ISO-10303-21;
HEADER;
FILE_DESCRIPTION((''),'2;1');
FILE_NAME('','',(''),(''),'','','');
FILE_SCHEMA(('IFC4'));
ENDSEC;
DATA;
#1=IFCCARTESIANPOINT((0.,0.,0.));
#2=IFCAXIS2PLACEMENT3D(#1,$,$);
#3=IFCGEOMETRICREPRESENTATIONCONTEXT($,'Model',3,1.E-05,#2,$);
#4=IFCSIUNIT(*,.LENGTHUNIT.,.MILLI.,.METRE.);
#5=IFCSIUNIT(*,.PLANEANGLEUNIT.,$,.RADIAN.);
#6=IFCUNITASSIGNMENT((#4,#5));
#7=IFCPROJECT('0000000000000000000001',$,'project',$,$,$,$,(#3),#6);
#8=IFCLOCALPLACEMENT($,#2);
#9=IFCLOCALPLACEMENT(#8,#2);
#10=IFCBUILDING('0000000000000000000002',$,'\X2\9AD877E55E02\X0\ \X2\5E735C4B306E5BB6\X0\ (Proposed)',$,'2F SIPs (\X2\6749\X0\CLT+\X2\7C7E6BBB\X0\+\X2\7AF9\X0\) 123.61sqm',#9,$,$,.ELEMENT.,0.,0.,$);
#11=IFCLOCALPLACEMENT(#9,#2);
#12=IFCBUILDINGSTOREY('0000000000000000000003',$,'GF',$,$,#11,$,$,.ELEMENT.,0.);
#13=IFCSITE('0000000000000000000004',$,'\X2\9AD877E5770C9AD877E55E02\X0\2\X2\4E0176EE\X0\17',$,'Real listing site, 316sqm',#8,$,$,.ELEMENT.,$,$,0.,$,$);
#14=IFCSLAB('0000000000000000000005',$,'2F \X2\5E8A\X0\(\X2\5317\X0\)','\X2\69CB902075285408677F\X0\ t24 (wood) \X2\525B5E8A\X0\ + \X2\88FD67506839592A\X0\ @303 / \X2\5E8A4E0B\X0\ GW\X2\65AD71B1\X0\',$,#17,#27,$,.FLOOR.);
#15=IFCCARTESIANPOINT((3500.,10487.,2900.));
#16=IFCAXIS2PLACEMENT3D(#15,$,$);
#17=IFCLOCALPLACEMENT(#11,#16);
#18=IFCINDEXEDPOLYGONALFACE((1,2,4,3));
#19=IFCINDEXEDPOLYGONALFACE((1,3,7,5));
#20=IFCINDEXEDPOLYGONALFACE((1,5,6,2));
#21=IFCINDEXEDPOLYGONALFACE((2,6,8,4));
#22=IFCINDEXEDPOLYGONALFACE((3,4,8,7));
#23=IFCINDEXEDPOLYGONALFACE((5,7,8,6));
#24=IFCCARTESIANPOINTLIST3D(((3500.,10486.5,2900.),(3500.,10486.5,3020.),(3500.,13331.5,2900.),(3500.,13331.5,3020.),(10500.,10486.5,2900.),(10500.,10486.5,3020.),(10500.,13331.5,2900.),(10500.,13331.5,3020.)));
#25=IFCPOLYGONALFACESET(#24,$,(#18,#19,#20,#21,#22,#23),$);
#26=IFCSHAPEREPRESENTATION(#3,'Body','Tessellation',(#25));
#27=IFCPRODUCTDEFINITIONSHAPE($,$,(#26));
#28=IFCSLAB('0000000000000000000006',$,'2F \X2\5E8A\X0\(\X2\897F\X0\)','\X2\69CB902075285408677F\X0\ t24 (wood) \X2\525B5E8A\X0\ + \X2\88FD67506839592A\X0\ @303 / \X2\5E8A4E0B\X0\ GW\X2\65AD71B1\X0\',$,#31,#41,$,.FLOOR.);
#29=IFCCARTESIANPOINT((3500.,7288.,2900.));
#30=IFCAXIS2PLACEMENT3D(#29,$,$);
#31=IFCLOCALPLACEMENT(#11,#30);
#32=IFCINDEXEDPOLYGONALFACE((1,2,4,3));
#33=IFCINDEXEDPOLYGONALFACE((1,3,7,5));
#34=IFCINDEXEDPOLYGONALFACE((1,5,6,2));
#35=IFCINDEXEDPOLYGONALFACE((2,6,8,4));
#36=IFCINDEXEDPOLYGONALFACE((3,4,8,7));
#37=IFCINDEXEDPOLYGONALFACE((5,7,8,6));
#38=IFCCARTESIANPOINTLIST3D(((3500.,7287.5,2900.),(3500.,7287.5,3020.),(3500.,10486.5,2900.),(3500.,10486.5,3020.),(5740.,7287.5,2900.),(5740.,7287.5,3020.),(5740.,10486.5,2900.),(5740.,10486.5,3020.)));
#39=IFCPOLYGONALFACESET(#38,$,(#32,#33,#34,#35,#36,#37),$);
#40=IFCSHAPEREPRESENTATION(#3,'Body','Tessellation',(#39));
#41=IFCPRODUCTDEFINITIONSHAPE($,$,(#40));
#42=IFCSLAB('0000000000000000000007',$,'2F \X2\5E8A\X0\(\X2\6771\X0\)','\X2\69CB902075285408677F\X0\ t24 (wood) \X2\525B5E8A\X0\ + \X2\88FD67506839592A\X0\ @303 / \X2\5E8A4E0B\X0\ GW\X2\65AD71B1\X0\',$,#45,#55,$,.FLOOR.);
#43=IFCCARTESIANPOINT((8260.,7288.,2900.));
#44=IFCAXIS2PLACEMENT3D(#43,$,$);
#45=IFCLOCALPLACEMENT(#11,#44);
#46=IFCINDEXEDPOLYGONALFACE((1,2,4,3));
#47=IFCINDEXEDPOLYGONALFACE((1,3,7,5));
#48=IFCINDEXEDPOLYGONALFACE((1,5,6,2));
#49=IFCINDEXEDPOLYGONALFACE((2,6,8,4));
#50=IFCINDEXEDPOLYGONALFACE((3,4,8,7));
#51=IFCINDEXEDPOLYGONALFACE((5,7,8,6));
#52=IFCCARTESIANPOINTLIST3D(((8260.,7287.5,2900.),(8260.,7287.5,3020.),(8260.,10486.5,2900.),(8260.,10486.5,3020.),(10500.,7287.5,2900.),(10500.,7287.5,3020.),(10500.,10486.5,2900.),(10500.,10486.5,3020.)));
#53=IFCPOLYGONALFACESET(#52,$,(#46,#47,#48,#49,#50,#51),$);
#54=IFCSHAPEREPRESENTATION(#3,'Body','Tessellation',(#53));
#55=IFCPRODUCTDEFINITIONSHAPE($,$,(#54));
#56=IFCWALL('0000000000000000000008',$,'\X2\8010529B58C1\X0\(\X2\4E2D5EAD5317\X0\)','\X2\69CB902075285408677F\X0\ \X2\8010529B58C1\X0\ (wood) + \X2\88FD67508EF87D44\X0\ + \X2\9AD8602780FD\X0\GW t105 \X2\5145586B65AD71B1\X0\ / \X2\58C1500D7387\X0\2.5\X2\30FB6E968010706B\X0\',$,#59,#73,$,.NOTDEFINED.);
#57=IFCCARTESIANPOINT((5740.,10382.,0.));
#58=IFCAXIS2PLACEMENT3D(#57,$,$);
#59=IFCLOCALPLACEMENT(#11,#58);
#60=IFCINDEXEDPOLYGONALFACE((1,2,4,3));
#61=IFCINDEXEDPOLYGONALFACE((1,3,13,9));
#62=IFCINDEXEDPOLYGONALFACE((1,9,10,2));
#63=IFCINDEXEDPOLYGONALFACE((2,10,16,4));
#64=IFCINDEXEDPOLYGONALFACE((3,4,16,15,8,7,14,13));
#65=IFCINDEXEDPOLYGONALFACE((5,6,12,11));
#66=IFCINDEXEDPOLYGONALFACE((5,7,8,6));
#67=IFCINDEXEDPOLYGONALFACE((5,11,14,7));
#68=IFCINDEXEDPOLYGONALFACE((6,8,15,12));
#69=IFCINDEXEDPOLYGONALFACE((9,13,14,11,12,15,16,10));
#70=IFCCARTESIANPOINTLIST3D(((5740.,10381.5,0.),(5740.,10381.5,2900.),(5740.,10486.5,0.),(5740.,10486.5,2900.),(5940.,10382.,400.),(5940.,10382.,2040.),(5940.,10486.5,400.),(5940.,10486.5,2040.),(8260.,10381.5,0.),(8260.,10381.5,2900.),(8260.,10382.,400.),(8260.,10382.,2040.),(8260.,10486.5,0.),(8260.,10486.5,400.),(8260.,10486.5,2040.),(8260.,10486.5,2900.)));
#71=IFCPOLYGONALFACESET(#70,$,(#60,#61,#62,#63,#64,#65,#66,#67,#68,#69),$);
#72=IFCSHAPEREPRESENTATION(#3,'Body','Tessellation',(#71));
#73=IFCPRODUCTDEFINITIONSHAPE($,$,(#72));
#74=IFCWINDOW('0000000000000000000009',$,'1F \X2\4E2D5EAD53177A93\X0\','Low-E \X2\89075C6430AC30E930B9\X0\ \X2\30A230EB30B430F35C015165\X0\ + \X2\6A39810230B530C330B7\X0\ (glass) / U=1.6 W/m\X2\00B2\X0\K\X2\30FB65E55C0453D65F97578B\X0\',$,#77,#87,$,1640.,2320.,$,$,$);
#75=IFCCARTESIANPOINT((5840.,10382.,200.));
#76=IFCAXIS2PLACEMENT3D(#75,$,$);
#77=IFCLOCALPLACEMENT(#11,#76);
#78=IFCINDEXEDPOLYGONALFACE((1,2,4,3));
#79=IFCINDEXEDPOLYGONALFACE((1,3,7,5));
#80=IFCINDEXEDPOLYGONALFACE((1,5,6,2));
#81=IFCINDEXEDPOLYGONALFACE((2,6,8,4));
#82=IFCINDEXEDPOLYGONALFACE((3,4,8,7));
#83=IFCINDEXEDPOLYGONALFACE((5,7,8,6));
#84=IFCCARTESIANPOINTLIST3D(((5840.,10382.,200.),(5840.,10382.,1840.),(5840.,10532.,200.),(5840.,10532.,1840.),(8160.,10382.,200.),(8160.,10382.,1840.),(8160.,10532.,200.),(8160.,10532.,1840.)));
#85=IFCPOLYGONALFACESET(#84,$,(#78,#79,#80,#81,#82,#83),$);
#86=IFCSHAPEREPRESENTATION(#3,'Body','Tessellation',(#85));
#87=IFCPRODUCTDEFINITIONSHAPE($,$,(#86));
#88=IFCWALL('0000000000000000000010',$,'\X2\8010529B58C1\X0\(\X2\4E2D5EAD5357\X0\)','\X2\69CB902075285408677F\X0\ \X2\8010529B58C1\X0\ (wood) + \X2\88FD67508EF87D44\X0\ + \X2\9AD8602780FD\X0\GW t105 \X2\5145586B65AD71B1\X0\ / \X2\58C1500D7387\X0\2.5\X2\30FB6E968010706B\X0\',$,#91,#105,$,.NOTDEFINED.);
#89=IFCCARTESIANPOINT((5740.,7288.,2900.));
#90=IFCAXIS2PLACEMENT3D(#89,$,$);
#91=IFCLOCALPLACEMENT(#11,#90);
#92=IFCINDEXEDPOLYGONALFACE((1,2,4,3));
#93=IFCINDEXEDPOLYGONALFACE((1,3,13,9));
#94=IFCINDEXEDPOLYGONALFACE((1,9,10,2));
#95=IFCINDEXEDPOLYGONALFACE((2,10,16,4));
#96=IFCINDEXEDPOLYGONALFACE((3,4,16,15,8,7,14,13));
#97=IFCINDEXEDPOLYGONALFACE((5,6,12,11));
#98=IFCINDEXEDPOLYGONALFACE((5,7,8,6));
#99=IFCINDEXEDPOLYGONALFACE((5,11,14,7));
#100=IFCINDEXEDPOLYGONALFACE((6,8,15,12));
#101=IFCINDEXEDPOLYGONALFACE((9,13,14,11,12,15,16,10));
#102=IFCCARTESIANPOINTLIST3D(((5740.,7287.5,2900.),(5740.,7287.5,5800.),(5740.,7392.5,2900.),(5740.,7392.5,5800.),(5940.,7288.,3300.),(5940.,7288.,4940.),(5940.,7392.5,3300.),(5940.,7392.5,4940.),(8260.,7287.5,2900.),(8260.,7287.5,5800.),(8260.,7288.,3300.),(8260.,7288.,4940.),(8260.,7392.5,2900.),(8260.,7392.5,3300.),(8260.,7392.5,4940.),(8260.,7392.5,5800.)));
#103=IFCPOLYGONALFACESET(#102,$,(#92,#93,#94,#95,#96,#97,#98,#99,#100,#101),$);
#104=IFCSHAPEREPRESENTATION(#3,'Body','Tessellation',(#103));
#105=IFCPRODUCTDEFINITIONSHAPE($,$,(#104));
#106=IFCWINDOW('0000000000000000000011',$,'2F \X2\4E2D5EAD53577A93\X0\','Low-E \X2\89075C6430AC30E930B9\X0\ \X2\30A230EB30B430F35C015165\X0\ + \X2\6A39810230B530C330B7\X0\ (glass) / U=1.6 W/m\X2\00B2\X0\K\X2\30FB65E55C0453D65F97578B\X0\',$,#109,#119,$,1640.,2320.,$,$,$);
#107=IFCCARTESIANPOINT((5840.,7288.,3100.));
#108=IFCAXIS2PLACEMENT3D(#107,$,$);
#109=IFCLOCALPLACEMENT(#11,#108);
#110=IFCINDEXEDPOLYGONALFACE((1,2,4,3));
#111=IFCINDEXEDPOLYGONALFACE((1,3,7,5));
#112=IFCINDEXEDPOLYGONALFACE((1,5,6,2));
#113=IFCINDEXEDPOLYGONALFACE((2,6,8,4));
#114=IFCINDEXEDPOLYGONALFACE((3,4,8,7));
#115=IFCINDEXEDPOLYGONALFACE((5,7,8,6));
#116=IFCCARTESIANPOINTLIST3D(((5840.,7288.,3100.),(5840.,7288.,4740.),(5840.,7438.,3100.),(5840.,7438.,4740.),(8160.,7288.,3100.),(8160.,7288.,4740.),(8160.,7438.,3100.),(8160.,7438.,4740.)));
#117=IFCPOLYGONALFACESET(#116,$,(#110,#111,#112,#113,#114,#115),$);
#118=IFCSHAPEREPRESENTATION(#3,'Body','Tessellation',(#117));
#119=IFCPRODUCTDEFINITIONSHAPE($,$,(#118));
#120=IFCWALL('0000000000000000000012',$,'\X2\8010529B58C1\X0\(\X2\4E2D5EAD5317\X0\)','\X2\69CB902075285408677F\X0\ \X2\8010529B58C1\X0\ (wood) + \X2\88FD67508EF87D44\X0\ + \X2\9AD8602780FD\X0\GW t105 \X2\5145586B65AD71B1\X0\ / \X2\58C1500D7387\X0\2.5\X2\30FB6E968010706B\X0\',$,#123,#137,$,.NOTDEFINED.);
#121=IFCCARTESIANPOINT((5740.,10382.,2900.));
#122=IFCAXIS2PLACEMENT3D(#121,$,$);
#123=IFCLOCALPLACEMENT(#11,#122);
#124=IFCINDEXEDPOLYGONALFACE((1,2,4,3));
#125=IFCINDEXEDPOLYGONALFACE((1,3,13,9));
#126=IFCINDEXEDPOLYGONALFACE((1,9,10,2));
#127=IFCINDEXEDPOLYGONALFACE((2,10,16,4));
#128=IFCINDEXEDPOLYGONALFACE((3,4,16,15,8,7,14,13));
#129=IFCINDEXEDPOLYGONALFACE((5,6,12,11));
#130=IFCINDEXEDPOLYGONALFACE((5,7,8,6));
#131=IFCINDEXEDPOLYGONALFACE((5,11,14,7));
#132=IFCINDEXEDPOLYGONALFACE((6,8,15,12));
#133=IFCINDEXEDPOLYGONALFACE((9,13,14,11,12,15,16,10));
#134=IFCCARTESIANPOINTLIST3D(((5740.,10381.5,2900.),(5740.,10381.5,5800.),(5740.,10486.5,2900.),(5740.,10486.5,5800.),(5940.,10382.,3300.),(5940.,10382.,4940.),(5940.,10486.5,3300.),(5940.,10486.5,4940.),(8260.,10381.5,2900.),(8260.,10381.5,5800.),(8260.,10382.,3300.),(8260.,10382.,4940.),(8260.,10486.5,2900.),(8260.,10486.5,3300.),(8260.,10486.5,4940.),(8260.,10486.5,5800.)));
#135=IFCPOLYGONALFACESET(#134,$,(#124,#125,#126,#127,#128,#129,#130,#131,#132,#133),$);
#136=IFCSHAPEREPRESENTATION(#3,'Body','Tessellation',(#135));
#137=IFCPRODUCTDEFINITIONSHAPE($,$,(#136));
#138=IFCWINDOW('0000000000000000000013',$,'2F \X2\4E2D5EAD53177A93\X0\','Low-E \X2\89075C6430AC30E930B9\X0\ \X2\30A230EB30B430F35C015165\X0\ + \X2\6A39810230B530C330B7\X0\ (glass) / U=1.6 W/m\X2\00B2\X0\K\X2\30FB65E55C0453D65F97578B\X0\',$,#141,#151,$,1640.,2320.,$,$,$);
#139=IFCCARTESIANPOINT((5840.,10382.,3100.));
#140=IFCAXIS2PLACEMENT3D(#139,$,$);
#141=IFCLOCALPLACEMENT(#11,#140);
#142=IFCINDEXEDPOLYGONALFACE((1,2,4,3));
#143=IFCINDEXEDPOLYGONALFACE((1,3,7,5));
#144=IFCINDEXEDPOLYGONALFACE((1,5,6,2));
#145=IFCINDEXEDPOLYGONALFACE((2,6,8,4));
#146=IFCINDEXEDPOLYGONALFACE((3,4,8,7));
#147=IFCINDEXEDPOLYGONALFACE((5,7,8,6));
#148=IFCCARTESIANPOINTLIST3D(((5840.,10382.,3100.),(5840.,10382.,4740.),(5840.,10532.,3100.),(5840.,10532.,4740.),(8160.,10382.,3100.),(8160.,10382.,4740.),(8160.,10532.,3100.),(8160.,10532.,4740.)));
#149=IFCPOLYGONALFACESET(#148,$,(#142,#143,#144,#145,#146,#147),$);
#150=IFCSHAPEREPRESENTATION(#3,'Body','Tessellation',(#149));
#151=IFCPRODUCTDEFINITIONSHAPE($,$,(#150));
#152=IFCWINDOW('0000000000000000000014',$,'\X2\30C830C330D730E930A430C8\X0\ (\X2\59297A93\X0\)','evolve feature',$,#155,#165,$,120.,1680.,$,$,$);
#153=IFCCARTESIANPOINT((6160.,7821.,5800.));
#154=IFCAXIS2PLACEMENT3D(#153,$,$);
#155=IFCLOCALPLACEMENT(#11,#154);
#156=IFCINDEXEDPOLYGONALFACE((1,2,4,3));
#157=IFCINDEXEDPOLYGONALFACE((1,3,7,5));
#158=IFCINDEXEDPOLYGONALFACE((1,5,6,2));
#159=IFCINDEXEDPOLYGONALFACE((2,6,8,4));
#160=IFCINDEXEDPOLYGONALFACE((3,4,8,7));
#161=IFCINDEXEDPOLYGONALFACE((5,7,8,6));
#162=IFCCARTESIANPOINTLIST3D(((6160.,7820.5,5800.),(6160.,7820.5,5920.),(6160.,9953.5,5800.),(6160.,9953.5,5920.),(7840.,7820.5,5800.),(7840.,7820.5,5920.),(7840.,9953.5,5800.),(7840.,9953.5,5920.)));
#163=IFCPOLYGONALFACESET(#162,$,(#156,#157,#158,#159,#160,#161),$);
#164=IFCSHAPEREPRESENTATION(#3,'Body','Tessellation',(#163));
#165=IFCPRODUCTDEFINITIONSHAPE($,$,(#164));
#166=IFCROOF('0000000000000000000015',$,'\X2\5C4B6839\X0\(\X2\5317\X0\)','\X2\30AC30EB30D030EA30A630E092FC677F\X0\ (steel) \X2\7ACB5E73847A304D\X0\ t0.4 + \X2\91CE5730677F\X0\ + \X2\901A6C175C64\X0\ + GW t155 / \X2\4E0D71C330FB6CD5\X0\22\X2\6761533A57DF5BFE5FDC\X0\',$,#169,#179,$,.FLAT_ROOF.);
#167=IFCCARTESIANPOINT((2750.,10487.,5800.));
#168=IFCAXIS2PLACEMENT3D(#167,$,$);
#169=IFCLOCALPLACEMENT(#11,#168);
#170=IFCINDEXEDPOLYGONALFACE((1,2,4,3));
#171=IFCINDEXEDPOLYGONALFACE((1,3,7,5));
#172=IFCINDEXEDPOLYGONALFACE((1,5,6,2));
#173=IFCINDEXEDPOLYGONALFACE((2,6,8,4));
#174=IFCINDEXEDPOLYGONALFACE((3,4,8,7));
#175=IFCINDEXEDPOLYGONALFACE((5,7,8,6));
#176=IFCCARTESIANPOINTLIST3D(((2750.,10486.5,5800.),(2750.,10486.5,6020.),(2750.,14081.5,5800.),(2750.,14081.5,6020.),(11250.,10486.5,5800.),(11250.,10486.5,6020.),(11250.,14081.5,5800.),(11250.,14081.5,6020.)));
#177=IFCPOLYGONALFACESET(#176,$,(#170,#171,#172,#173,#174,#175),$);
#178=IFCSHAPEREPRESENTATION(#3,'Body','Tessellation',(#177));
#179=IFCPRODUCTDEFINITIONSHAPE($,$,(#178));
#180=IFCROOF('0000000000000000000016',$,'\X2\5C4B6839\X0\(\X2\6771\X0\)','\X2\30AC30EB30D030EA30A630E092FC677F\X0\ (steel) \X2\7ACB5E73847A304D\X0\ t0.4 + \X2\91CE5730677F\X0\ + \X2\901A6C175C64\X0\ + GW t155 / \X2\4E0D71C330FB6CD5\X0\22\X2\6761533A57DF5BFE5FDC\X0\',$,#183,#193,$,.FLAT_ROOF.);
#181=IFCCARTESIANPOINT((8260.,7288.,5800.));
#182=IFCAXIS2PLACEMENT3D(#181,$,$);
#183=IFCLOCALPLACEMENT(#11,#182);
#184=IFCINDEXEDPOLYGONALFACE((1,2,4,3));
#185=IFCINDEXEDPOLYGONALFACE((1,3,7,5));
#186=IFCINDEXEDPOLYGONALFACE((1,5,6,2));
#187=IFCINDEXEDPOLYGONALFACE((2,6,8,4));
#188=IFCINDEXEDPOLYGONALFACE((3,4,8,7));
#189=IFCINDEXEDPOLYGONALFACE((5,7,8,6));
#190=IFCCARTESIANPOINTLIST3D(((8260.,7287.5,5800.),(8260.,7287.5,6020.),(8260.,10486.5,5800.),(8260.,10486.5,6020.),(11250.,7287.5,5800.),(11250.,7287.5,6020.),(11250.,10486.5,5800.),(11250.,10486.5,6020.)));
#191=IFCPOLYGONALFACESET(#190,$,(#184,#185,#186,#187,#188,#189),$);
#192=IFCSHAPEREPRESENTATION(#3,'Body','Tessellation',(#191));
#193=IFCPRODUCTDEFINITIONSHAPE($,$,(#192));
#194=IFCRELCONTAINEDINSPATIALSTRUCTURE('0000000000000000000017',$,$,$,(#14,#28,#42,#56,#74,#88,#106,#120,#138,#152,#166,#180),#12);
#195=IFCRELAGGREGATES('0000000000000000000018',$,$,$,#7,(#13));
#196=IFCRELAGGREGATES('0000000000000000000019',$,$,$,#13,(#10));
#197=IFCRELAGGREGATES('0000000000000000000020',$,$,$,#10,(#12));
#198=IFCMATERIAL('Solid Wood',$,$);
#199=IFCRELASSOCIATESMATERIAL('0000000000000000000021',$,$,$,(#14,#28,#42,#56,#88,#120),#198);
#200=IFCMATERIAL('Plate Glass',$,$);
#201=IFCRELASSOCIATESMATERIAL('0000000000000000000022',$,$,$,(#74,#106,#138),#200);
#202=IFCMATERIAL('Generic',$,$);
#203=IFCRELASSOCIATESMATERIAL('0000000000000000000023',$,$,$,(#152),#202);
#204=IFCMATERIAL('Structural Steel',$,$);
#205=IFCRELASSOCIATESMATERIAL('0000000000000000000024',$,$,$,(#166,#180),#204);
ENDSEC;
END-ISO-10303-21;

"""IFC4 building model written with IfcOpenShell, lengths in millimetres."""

from ifc_helpers import new_model, si_unit, frame, frame_2d, origin, place, context, project, spatial, rectangle, extrude, material, element, fill, save


model = new_model("IFC4")

# Units and contexts
model_context = context("Model", 3, precision=1e-05, world=origin())
ifc_project = project(units=[si_unit("LENGTHUNIT", "METRE", prefix="MILLI"), si_unit("PLANEANGLEUNIT", "RADIAN")], contexts=[model_context])

# Site, building, storey
site_placement = place(None, origin())
site = spatial("IfcSite", under=ifc_project, at=site_placement, Name="高知県高知市2丁目17", ObjectType="Real listing site, 316sqm", CompositionType="ELEMENT", RefElevation=0.0)
building_placement = place(site_placement, origin())
building = spatial("IfcBuilding", under=site, at=building_placement, Name="高知市 平屋の家 (Proposed)", ObjectType="2F SIPs (杉CLT+籾殻+竹) 123.61sqm", CompositionType="ELEMENT", ElevationOfRefHeight=0.0, ElevationOfTerrain=0.0)
storey_placement = place(building_placement, origin())
storey = spatial("IfcBuildingStorey", under=building, at=storey_placement, Name="GF", CompositionType="ELEMENT", Elevation=0.0)

# Slabs
ifc_material_1 = material(Name="Solid Wood")
slab_1_placement = place(storey_placement, frame((3500.0, 10487.0, 2900.0)))
element("IfcSlab", 1, at=slab_1_placement, inside=storey, material=ifc_material_1, Name="2F 床(北)", Description="構造用合板 t24 (wood) 剛床 + 製材根太 @303 / 床下 GW断熱", PredefinedType="FLOOR", context=model_context, shape_type="SweptSolid", body=[
    extrude(rectangle(XDim=7000.0, YDim=2845.0, at=frame_2d((3500.0, 1422.0))), frame((3500.0, 10487.0, 2900.0)), (0.0, 0.0, 1.0), 120.0),
])
slab_2_placement = place(storey_placement, frame((3500.0, 7288.0, 2900.0)))
element("IfcSlab", 2, at=slab_2_placement, inside=storey, material=ifc_material_1, Name="2F 床(西)", Description="構造用合板 t24 (wood) 剛床 + 製材根太 @303 / 床下 GW断熱", PredefinedType="FLOOR", context=model_context, shape_type="SweptSolid", body=[
    extrude(rectangle(XDim=2240.0, YDim=3199.0, at=frame_2d((1120.0, 1599.0))), frame((3500.0, 7288.0, 2900.0)), (0.0, 0.0, 1.0), 120.0),
])
slab_3_placement = place(storey_placement, frame((8260.0, 7288.0, 2900.0)))
element("IfcSlab", 3, at=slab_3_placement, inside=storey, material=ifc_material_1, Name="2F 床(東)", Description="構造用合板 t24 (wood) 剛床 + 製材根太 @303 / 床下 GW断熱", PredefinedType="FLOOR", context=model_context, shape_type="SweptSolid", body=[
    extrude(rectangle(XDim=2240.0, YDim=3199.0, at=frame_2d((1120.0, 1599.0))), frame((8260.0, 7288.0, 2900.0)), (0.0, 0.0, 1.0), 120.0),
])

# Wall, opening, window
wall_1_placement = place(storey_placement, frame((5740.0, 10382.0, 0.0)))
wall_1 = element("IfcWall", 4, at=wall_1_placement, inside=storey, material=ifc_material_1, Name="耐力壁(中庭北)", Description="構造用合板 耐力壁 (wood) + 製材軸組 + 高性能GW t105 充填断熱 / 壁倍率2.5・準耐火", PredefinedType="NOTDEFINED", context=model_context, shape_type="SweptSolid", body=[
    extrude(rectangle(XDim=2520.0, YDim=105.0, at=frame_2d((1260.0, 52.0))), frame((5740.0, 10382.0, 0.0)), (0.0, 0.0, 1.0), 2900.0),
])
opening_1_placement = place(storey_placement, frame((5840.0, 10382.0, 200.0)))
opening_1 = element("IfcOpeningElement", 5, at=opening_1_placement, cuts=wall_1, PredefinedType="NOTDEFINED", context=model_context, shape_type="SweptSolid", body=[
    extrude(rectangle(XDim=2320.0, YDim=150.0, at=frame_2d((1160.0, 75.0))), frame((5840.0, 10382.0, 200.0)), (0.0, 0.0, 1.0), 1640.0),
])
ifc_material_2 = material(Name="Plate Glass")
window_1_placement = place(storey_placement, frame((5840.0, 10382.0, 200.0)))
window_1 = element("IfcWindow", 6, at=window_1_placement, inside=storey, material=ifc_material_2, Name="1F 中庭北窓", Description="Low-E 複層ガラス アルゴン封入 + 樹脂サッシ (glass) / U=1.6 W/m²K・日射取得型", OverallHeight=1640.0, OverallWidth=2320.0, context=model_context, shape_type="SweptSolid", body=[
    extrude(rectangle(XDim=2320.0, YDim=150.0, at=frame_2d((1160.0, 75.0))), frame((5840.0, 10382.0, 200.0)), (0.0, 0.0, 1.0), 1640.0),
])
fill(opening_1, window_1)

# Walls, openings, windows
wall_2_placement = place(storey_placement, frame((5740.0, 7288.0, 2900.0)))
wall_2 = element("IfcWall", 7, at=wall_2_placement, inside=storey, material=ifc_material_1, Name="耐力壁(中庭南)", Description="構造用合板 耐力壁 (wood) + 製材軸組 + 高性能GW t105 充填断熱 / 壁倍率2.5・準耐火", PredefinedType="NOTDEFINED", context=model_context, shape_type="SweptSolid", body=[
    extrude(rectangle(XDim=2520.0, YDim=105.0, at=frame_2d((1260.0, 52.0))), frame((5740.0, 7288.0, 2900.0)), (0.0, 0.0, 1.0), 2900.0),
])
opening_2_placement = place(storey_placement, frame((5840.0, 7288.0, 3100.0)))
opening_2 = element("IfcOpeningElement", 8, at=opening_2_placement, cuts=wall_2, PredefinedType="NOTDEFINED", context=model_context, shape_type="SweptSolid", body=[
    extrude(rectangle(XDim=2320.0, YDim=150.0, at=frame_2d((1160.0, 75.0))), frame((5840.0, 7288.0, 3100.0)), (0.0, 0.0, 1.0), 1640.0),
])
window_2_placement = place(storey_placement, frame((5840.0, 7288.0, 3100.0)))
window_2 = element("IfcWindow", 9, at=window_2_placement, inside=storey, material=ifc_material_2, Name="2F 中庭南窓", Description="Low-E 複層ガラス アルゴン封入 + 樹脂サッシ (glass) / U=1.6 W/m²K・日射取得型", OverallHeight=1640.0, OverallWidth=2320.0, context=model_context, shape_type="SweptSolid", body=[
    extrude(rectangle(XDim=2320.0, YDim=150.0, at=frame_2d((1160.0, 75.0))), frame((5840.0, 7288.0, 3100.0)), (0.0, 0.0, 1.0), 1640.0),
])
fill(opening_2, window_2)
wall_3_placement = place(storey_placement, frame((5740.0, 10382.0, 2900.0)))
wall_3 = element("IfcWall", 10, at=wall_3_placement, inside=storey, material=ifc_material_1, Name="耐力壁(中庭北)", Description="構造用合板 耐力壁 (wood) + 製材軸組 + 高性能GW t105 充填断熱 / 壁倍率2.5・準耐火", PredefinedType="NOTDEFINED", context=model_context, shape_type="SweptSolid", body=[
    extrude(rectangle(XDim=2520.0, YDim=105.0, at=frame_2d((1260.0, 52.0))), frame((5740.0, 10382.0, 2900.0)), (0.0, 0.0, 1.0), 2900.0),
])
opening_3_placement = place(storey_placement, frame((5840.0, 10382.0, 3100.0)))
opening_3 = element("IfcOpeningElement", 11, at=opening_3_placement, cuts=wall_3, PredefinedType="NOTDEFINED", context=model_context, shape_type="SweptSolid", body=[
    extrude(rectangle(XDim=2320.0, YDim=150.0, at=frame_2d((1160.0, 75.0))), frame((5840.0, 10382.0, 3100.0)), (0.0, 0.0, 1.0), 1640.0),
])
window_3_placement = place(storey_placement, frame((5840.0, 10382.0, 3100.0)))
window_3 = element("IfcWindow", 12, at=window_3_placement, inside=storey, material=ifc_material_2, Name="2F 中庭北窓", Description="Low-E 複層ガラス アルゴン封入 + 樹脂サッシ (glass) / U=1.6 W/m²K・日射取得型", OverallHeight=1640.0, OverallWidth=2320.0, context=model_context, shape_type="SweptSolid", body=[
    extrude(rectangle(XDim=2320.0, YDim=150.0, at=frame_2d((1160.0, 75.0))), frame((5840.0, 10382.0, 3100.0)), (0.0, 0.0, 1.0), 1640.0),
])
fill(opening_3, window_3)

# Window
ifc_material_3 = material(Name="Generic")
window_4_placement = place(storey_placement, frame((6160.0, 7821.0, 5800.0)))
element("IfcWindow", 13, at=window_4_placement, inside=storey, material=ifc_material_3, Name="トップライト (天窓)", Description="evolve feature", OverallHeight=120.0, OverallWidth=1680.0, context=model_context, shape_type="SweptSolid", body=[
    extrude(rectangle(XDim=1680.0, YDim=2133.0, at=frame_2d((840.0, 1066.0))), frame((6160.0, 7821.0, 5800.0)), (0.0, 0.0, 1.0), 120.0),
])

# Roofs
ifc_material_4 = material(Name="Structural Steel")
roof_1_placement = place(storey_placement, frame((2750.0, 10487.0, 5800.0)))
element("IfcRoof", 14, at=roof_1_placement, inside=storey, material=ifc_material_4, Name="屋根(北)", Description="ガルバリウム鋼板 (steel) 立平葺き t0.4 + 野地板 + 通気層 + GW t155 / 不燃・法22条区域対応", PredefinedType="FLAT_ROOF", context=model_context, shape_type="SweptSolid", body=[
    extrude(rectangle(XDim=8500.0, YDim=3595.0, at=frame_2d((4250.0, 1797.0))), frame((2750.0, 10487.0, 5800.0)), (0.0, 0.0, 1.0), 220.0),
])
roof_2_placement = place(storey_placement, frame((8260.0, 7288.0, 5800.0)))
element("IfcRoof", 15, at=roof_2_placement, inside=storey, material=ifc_material_4, Name="屋根(東)", Description="ガルバリウム鋼板 (steel) 立平葺き t0.4 + 野地板 + 通気層 + GW t155 / 不燃・法22条区域対応", PredefinedType="FLAT_ROOF", context=model_context, shape_type="SweptSolid", body=[
    extrude(rectangle(XDim=2990.0, YDim=3199.0, at=frame_2d((1495.0, 1599.0))), frame((8260.0, 7288.0, 5800.0)), (0.0, 0.0, 1.0), 220.0),
])

save(model, "model.ifc")
